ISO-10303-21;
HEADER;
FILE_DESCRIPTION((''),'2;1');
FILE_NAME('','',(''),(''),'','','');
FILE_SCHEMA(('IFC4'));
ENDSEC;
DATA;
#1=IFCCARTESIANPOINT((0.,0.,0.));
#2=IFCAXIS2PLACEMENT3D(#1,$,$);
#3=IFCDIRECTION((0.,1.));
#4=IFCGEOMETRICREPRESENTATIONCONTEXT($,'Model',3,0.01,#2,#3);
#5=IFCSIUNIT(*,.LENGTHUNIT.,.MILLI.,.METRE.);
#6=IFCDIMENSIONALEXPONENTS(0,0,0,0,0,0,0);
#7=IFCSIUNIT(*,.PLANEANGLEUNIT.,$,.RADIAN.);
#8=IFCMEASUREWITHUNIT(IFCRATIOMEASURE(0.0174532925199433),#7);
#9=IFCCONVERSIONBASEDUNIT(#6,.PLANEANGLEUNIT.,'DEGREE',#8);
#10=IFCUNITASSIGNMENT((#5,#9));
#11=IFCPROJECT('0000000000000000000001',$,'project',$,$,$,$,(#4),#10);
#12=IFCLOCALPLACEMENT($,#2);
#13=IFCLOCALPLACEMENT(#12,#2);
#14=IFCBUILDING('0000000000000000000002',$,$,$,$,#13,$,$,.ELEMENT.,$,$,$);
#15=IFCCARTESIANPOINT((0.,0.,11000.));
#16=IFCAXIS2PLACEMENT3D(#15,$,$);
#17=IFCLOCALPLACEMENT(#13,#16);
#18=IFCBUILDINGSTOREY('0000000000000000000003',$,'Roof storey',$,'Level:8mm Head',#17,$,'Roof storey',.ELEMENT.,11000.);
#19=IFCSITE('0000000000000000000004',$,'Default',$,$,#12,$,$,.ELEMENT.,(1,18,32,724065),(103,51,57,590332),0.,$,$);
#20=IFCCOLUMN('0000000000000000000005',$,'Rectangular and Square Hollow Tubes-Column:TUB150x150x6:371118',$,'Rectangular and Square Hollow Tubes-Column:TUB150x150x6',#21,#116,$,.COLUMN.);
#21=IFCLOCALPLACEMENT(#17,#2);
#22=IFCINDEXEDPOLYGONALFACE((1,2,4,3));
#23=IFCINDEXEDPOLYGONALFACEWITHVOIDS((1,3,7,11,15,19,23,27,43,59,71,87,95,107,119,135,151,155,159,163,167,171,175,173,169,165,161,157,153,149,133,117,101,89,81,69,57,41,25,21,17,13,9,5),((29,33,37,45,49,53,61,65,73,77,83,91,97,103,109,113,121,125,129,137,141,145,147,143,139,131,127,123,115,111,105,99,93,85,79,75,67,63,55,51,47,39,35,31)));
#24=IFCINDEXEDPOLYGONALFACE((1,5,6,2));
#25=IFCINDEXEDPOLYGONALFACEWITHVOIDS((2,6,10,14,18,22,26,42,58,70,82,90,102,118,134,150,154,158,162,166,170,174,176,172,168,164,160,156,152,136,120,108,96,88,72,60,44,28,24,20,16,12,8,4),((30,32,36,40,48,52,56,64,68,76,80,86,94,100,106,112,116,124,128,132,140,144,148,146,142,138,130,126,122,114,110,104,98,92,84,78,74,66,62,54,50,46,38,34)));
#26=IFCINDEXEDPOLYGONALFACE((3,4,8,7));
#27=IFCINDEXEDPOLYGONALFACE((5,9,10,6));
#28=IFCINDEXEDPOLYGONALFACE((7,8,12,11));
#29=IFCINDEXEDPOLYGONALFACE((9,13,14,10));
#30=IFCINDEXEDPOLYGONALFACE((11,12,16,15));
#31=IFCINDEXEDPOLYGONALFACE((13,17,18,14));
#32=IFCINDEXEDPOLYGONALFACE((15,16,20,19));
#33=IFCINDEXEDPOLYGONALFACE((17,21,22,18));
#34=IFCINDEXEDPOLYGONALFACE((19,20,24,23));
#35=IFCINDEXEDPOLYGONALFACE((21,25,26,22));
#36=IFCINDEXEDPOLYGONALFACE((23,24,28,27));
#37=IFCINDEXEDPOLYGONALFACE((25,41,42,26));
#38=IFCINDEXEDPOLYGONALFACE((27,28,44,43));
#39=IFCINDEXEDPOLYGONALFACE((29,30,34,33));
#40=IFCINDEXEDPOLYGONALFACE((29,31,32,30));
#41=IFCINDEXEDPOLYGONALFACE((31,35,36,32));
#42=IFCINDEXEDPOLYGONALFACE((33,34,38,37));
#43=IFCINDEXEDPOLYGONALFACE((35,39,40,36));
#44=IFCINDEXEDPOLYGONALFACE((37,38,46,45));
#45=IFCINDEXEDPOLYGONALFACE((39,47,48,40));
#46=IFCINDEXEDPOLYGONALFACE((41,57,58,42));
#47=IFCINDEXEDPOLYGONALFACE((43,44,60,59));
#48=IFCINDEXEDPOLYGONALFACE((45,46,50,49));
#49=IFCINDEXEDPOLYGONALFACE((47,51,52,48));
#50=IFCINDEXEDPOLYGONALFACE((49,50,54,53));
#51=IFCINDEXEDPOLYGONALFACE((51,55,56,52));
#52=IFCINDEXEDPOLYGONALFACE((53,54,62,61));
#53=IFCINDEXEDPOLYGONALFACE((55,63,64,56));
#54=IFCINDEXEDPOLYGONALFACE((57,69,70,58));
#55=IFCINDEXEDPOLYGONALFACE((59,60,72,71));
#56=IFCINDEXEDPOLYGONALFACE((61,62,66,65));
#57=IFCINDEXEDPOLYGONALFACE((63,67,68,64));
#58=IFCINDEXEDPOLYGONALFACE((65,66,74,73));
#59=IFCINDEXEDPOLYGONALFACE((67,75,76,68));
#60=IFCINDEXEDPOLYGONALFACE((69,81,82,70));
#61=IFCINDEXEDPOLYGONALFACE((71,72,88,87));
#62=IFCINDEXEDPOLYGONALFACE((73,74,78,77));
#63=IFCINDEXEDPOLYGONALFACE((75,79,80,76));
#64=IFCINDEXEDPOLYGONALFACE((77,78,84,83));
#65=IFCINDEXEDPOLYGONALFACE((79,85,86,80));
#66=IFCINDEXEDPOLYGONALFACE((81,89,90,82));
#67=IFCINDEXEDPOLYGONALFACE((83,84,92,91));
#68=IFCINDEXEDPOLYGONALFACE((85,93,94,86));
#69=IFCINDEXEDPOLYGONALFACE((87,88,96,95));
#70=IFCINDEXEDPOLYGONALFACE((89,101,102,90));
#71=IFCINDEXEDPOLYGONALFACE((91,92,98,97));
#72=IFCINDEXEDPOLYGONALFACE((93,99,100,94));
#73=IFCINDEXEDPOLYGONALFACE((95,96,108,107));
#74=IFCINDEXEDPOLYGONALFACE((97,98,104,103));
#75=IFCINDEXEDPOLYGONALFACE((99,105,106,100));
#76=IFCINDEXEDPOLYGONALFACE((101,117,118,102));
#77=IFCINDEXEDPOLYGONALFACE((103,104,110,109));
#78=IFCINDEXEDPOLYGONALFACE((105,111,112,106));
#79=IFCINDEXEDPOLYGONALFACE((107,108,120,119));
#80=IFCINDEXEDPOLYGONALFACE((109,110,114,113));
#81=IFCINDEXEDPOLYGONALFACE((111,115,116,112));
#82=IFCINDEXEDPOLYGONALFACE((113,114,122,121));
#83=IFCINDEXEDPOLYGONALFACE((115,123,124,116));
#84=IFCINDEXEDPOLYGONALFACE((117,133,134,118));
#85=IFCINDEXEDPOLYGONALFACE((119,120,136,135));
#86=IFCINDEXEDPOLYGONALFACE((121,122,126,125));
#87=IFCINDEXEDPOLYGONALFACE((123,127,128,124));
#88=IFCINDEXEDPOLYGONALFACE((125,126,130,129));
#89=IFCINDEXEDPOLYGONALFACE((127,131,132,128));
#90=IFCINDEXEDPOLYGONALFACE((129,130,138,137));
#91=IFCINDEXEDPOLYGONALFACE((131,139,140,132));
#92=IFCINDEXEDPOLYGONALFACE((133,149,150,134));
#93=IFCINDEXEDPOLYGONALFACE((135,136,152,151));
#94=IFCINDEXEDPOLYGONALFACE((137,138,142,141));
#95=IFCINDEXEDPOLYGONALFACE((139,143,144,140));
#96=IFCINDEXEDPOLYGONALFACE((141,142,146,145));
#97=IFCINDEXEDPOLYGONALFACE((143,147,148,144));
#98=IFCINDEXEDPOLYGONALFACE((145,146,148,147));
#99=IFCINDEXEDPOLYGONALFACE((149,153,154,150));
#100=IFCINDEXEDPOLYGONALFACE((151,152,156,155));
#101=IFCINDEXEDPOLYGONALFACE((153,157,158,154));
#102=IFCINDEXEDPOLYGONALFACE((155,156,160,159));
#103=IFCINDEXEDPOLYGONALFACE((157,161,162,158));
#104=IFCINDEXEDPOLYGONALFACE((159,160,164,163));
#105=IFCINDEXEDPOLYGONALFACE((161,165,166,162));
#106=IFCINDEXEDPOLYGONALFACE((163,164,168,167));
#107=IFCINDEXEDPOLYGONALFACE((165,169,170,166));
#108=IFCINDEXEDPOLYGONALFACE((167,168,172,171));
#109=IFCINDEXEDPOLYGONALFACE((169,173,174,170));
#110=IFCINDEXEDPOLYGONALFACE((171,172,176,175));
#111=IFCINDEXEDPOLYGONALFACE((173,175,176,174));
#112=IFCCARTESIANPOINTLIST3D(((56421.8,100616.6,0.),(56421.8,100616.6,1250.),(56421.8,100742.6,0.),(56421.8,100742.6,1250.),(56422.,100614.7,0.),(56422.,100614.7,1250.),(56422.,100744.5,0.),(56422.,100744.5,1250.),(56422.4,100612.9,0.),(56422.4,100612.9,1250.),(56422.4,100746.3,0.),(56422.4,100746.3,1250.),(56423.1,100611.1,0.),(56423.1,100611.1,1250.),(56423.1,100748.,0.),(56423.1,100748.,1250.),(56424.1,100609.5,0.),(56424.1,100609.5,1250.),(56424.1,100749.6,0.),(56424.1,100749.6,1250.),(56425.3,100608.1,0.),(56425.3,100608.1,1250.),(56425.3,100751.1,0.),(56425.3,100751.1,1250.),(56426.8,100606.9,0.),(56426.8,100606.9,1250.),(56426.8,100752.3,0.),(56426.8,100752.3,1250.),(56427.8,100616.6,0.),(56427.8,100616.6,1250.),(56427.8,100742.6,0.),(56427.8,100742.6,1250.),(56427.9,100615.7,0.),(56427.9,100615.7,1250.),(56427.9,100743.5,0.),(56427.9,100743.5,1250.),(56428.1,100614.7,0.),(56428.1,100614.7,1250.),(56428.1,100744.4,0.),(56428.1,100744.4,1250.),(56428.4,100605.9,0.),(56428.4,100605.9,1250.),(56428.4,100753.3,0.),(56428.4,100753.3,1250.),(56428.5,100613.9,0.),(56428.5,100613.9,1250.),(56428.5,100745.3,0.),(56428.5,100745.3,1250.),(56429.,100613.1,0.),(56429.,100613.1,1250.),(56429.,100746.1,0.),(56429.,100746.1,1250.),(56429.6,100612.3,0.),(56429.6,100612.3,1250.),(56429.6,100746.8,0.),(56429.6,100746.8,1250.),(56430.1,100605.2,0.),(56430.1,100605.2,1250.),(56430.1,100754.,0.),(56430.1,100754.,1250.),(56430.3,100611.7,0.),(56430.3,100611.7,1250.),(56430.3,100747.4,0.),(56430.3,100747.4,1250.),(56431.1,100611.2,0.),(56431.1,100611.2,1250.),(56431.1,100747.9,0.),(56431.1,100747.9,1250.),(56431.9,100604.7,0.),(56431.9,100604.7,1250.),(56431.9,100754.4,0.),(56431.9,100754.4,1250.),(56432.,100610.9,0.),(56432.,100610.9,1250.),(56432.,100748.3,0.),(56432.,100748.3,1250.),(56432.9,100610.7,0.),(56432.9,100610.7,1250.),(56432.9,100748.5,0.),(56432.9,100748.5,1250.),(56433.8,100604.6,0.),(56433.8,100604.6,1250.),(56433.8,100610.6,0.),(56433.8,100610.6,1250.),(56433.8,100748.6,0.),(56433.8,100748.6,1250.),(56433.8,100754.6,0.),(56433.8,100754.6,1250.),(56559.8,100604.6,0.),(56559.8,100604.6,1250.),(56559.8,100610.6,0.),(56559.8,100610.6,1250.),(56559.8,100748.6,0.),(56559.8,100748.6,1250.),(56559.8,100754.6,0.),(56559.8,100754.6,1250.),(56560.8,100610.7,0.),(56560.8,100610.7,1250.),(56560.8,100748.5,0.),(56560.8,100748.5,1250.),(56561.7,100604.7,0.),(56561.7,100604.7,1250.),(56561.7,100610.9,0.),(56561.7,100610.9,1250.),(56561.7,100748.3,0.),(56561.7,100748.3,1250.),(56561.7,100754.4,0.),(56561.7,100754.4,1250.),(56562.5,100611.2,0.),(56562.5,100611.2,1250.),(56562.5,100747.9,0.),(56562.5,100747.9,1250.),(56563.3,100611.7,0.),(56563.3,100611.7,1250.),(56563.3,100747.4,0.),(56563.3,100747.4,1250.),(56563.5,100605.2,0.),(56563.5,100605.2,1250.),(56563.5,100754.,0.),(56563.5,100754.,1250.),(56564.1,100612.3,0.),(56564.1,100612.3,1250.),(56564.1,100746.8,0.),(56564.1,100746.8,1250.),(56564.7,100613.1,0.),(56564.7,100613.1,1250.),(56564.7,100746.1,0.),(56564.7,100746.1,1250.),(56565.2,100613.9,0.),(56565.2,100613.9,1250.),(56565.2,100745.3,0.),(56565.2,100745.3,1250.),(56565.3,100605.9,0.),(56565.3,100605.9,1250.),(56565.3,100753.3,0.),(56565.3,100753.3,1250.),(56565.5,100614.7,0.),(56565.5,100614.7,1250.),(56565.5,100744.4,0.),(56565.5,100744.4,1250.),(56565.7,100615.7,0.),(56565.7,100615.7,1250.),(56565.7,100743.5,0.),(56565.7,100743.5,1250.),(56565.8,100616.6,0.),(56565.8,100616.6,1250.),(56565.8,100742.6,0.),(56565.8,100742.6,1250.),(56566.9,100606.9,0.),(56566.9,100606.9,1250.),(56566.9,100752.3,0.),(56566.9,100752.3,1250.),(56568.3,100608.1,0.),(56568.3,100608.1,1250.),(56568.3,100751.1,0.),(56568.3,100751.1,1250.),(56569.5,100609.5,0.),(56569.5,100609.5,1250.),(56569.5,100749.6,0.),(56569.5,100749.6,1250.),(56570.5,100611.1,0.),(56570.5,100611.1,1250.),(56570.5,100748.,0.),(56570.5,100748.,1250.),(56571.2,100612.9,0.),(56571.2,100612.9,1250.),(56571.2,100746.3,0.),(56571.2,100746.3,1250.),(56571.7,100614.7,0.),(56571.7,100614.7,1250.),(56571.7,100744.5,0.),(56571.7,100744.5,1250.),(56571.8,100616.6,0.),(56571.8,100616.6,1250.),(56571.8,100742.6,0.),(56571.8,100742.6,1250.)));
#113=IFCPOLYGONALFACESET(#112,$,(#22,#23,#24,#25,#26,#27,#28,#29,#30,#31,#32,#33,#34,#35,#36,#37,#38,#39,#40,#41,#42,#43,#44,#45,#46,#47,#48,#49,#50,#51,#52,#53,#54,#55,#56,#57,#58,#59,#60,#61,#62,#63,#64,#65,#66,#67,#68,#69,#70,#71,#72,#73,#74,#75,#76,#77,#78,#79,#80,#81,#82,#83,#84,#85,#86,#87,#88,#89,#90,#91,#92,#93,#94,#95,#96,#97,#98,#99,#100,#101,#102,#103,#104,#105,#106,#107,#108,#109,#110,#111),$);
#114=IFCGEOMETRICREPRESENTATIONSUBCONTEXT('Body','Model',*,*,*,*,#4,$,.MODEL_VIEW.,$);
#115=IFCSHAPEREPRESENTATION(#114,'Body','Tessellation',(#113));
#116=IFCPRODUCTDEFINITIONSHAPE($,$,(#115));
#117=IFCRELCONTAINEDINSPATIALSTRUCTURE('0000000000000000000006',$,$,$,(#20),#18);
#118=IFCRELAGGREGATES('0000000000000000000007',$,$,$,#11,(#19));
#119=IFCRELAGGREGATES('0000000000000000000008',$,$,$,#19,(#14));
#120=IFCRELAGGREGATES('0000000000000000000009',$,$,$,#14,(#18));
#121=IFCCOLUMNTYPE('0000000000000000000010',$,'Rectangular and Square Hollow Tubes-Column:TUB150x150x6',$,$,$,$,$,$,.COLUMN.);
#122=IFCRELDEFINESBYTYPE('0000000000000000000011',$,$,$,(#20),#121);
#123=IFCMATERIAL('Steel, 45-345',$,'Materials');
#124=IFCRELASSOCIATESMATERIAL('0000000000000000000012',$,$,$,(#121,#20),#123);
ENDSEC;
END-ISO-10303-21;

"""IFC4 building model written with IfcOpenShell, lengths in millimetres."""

from ifc_helpers import new_model, entity, si_unit, converted_unit, direction, frame, origin, place, context, subcontext, project, spatial, indexed_curve, outline, extrude, source, transform, mapped, material, type_object, type_shapes, element, save


model = new_model("IFC4")

# Units and contexts
model_context = context("Model", 3, precision=0.01, world=origin(), true_north=direction((0.0, 1.0)))
body_context = subcontext(model_context, "Body", "Model", "MODEL_VIEW")
ifc_project = project(units=[si_unit("LENGTHUNIT", "METRE", prefix="MILLI"), converted_unit("PLANEANGLEUNIT", "DEGREE", entity("IfcRatioMeasure", 0.0174532925199433), si_unit("PLANEANGLEUNIT", "RADIAN"), dimensions=[0, 0, 0, 0, 0, 0, 0])], contexts=[model_context])

# Site, building, storey
site_placement = place(None, origin())
site = spatial("IfcSite", under=ifc_project, at=site_placement, Name="Default", CompositionType="ELEMENT", RefLatitude=(1, 18, 32, 724065), RefLongitude=(103, 51, 57, 590332), RefElevation=0.0)
building_placement = place(site_placement, origin())
building = spatial("IfcBuilding", under=site, at=building_placement, CompositionType="ELEMENT")
storey_placement = place(building_placement, frame((0.0, 0.0, 11000.0)))
storey = spatial("IfcBuildingStorey", under=building, at=storey_placement, Name="Roof storey", ObjectType="Level:8mm Head", LongName="Roof storey", CompositionType="ELEMENT", Elevation=11000.0)

# Column
ifc_material = material(Name="Steel, 45-345", Category="Materials")
column_type = type_object("IfcColumnType", Name="Rectangular and Square Hollow Tubes-Column:TUB150x150x6", PredefinedType="COLUMN", material=ifc_material)
shared_shape_1 = source(origin(), body_context, "Body", "SweptSolid", [
    extrude(outline(indexed_curve([(-63.0, -75.0), (63.0, -75.0), (64.9, -74.9), (66.7, -74.4), (68.4, -73.7), (70.1, -72.7), (71.5, -71.5), (72.7, -70.1), (73.7, -68.4), (74.4, -66.7), (74.9, -64.9), (75.0, -63.0), (75.0, 63.0), (74.9, 64.9), (74.4, 66.7), (73.7, 68.4), (72.7, 70.1), (71.5, 71.5), (70.1, 72.7), (68.4, 73.7), (66.7, 74.4), (64.9, 74.9), (63.0, 75.0), (-63.0, 75.0), (-64.9, 74.9), (-66.7, 74.4), (-68.4, 73.7), (-70.1, 72.7), (-71.5, 71.5), (-72.7, 70.1), (-73.7, 68.4), (-74.4, 66.7), (-74.9, 64.9), (-75.0, 63.0), (-75.0, -63.0), (-74.9, -64.9), (-74.4, -66.7), (-73.7, -68.4), (-72.7, -70.1), (-71.5, -71.5), (-70.1, -72.7), (-68.4, -73.7), (-66.7, -74.4), (-64.9, -74.9), (-63.0, -75.0)], self_intersect=False), holes=[indexed_curve([(-63.0, -69.0), (-63.9, -68.9), (-64.9, -68.7), (-65.7, -68.3), (-66.5, -67.9), (-67.2, -67.2), (-67.9, -66.5), (-68.3, -65.7), (-68.7, -64.9), (-68.9, -63.9), (-69.0, -63.0), (-69.0, 63.0), (-68.9, 63.9), (-68.7, 64.9), (-68.3, 65.7), (-67.9, 66.5), (-67.2, 67.2), (-66.5, 67.9), (-65.7, 68.3), (-64.9, 68.7), (-63.9, 68.9), (-63.0, 69.0), (63.0, 69.0), (63.9, 68.9), (64.9, 68.7), (65.7, 68.3), (66.5, 67.9), (67.2, 67.2), (67.9, 66.5), (68.3, 65.7), (68.7, 64.9), (68.9, 63.9), (69.0, 63.0), (69.0, -63.0), (68.9, -63.9), (68.7, -64.9), (68.3, -65.7), (67.9, -66.5), (67.2, -67.2), (66.5, -67.9), (65.7, -68.3), (64.9, -68.7), (63.9, -68.9), (63.0, -69.0), (-63.0, -69.0)], self_intersect=False)]), frame((0.0, 0.0, 11000.0), z_axis=(0.0, 0.0, 1.0), x_axis=(-1.0, 0.0, 0.0)), (0.0, 0.0, 1.0), 1250.0),
])
type_shapes(column_type, [shared_shape_1])
for number, where, name in (
    (1, (56496.8, 100679.6, -11000.0), "Rectangular and Square Hollow Tubes-Column:TUB150x150x6:371118"),
):
    element("IfcColumn", number, at=place(storey_placement, frame(where)), inside=storey, type_object=column_type, material=ifc_material, Name=name, ObjectType="Rectangular and Square Hollow Tubes-Column:TUB150x150x6", PredefinedType="COLUMN", context=body_context, shape_type="MappedRepresentation", body=[
        mapped(shared_shape_1, transform((0.0, 0.0, 0.0), scale=1.0)),
    ])

save(model, "model.ifc")
